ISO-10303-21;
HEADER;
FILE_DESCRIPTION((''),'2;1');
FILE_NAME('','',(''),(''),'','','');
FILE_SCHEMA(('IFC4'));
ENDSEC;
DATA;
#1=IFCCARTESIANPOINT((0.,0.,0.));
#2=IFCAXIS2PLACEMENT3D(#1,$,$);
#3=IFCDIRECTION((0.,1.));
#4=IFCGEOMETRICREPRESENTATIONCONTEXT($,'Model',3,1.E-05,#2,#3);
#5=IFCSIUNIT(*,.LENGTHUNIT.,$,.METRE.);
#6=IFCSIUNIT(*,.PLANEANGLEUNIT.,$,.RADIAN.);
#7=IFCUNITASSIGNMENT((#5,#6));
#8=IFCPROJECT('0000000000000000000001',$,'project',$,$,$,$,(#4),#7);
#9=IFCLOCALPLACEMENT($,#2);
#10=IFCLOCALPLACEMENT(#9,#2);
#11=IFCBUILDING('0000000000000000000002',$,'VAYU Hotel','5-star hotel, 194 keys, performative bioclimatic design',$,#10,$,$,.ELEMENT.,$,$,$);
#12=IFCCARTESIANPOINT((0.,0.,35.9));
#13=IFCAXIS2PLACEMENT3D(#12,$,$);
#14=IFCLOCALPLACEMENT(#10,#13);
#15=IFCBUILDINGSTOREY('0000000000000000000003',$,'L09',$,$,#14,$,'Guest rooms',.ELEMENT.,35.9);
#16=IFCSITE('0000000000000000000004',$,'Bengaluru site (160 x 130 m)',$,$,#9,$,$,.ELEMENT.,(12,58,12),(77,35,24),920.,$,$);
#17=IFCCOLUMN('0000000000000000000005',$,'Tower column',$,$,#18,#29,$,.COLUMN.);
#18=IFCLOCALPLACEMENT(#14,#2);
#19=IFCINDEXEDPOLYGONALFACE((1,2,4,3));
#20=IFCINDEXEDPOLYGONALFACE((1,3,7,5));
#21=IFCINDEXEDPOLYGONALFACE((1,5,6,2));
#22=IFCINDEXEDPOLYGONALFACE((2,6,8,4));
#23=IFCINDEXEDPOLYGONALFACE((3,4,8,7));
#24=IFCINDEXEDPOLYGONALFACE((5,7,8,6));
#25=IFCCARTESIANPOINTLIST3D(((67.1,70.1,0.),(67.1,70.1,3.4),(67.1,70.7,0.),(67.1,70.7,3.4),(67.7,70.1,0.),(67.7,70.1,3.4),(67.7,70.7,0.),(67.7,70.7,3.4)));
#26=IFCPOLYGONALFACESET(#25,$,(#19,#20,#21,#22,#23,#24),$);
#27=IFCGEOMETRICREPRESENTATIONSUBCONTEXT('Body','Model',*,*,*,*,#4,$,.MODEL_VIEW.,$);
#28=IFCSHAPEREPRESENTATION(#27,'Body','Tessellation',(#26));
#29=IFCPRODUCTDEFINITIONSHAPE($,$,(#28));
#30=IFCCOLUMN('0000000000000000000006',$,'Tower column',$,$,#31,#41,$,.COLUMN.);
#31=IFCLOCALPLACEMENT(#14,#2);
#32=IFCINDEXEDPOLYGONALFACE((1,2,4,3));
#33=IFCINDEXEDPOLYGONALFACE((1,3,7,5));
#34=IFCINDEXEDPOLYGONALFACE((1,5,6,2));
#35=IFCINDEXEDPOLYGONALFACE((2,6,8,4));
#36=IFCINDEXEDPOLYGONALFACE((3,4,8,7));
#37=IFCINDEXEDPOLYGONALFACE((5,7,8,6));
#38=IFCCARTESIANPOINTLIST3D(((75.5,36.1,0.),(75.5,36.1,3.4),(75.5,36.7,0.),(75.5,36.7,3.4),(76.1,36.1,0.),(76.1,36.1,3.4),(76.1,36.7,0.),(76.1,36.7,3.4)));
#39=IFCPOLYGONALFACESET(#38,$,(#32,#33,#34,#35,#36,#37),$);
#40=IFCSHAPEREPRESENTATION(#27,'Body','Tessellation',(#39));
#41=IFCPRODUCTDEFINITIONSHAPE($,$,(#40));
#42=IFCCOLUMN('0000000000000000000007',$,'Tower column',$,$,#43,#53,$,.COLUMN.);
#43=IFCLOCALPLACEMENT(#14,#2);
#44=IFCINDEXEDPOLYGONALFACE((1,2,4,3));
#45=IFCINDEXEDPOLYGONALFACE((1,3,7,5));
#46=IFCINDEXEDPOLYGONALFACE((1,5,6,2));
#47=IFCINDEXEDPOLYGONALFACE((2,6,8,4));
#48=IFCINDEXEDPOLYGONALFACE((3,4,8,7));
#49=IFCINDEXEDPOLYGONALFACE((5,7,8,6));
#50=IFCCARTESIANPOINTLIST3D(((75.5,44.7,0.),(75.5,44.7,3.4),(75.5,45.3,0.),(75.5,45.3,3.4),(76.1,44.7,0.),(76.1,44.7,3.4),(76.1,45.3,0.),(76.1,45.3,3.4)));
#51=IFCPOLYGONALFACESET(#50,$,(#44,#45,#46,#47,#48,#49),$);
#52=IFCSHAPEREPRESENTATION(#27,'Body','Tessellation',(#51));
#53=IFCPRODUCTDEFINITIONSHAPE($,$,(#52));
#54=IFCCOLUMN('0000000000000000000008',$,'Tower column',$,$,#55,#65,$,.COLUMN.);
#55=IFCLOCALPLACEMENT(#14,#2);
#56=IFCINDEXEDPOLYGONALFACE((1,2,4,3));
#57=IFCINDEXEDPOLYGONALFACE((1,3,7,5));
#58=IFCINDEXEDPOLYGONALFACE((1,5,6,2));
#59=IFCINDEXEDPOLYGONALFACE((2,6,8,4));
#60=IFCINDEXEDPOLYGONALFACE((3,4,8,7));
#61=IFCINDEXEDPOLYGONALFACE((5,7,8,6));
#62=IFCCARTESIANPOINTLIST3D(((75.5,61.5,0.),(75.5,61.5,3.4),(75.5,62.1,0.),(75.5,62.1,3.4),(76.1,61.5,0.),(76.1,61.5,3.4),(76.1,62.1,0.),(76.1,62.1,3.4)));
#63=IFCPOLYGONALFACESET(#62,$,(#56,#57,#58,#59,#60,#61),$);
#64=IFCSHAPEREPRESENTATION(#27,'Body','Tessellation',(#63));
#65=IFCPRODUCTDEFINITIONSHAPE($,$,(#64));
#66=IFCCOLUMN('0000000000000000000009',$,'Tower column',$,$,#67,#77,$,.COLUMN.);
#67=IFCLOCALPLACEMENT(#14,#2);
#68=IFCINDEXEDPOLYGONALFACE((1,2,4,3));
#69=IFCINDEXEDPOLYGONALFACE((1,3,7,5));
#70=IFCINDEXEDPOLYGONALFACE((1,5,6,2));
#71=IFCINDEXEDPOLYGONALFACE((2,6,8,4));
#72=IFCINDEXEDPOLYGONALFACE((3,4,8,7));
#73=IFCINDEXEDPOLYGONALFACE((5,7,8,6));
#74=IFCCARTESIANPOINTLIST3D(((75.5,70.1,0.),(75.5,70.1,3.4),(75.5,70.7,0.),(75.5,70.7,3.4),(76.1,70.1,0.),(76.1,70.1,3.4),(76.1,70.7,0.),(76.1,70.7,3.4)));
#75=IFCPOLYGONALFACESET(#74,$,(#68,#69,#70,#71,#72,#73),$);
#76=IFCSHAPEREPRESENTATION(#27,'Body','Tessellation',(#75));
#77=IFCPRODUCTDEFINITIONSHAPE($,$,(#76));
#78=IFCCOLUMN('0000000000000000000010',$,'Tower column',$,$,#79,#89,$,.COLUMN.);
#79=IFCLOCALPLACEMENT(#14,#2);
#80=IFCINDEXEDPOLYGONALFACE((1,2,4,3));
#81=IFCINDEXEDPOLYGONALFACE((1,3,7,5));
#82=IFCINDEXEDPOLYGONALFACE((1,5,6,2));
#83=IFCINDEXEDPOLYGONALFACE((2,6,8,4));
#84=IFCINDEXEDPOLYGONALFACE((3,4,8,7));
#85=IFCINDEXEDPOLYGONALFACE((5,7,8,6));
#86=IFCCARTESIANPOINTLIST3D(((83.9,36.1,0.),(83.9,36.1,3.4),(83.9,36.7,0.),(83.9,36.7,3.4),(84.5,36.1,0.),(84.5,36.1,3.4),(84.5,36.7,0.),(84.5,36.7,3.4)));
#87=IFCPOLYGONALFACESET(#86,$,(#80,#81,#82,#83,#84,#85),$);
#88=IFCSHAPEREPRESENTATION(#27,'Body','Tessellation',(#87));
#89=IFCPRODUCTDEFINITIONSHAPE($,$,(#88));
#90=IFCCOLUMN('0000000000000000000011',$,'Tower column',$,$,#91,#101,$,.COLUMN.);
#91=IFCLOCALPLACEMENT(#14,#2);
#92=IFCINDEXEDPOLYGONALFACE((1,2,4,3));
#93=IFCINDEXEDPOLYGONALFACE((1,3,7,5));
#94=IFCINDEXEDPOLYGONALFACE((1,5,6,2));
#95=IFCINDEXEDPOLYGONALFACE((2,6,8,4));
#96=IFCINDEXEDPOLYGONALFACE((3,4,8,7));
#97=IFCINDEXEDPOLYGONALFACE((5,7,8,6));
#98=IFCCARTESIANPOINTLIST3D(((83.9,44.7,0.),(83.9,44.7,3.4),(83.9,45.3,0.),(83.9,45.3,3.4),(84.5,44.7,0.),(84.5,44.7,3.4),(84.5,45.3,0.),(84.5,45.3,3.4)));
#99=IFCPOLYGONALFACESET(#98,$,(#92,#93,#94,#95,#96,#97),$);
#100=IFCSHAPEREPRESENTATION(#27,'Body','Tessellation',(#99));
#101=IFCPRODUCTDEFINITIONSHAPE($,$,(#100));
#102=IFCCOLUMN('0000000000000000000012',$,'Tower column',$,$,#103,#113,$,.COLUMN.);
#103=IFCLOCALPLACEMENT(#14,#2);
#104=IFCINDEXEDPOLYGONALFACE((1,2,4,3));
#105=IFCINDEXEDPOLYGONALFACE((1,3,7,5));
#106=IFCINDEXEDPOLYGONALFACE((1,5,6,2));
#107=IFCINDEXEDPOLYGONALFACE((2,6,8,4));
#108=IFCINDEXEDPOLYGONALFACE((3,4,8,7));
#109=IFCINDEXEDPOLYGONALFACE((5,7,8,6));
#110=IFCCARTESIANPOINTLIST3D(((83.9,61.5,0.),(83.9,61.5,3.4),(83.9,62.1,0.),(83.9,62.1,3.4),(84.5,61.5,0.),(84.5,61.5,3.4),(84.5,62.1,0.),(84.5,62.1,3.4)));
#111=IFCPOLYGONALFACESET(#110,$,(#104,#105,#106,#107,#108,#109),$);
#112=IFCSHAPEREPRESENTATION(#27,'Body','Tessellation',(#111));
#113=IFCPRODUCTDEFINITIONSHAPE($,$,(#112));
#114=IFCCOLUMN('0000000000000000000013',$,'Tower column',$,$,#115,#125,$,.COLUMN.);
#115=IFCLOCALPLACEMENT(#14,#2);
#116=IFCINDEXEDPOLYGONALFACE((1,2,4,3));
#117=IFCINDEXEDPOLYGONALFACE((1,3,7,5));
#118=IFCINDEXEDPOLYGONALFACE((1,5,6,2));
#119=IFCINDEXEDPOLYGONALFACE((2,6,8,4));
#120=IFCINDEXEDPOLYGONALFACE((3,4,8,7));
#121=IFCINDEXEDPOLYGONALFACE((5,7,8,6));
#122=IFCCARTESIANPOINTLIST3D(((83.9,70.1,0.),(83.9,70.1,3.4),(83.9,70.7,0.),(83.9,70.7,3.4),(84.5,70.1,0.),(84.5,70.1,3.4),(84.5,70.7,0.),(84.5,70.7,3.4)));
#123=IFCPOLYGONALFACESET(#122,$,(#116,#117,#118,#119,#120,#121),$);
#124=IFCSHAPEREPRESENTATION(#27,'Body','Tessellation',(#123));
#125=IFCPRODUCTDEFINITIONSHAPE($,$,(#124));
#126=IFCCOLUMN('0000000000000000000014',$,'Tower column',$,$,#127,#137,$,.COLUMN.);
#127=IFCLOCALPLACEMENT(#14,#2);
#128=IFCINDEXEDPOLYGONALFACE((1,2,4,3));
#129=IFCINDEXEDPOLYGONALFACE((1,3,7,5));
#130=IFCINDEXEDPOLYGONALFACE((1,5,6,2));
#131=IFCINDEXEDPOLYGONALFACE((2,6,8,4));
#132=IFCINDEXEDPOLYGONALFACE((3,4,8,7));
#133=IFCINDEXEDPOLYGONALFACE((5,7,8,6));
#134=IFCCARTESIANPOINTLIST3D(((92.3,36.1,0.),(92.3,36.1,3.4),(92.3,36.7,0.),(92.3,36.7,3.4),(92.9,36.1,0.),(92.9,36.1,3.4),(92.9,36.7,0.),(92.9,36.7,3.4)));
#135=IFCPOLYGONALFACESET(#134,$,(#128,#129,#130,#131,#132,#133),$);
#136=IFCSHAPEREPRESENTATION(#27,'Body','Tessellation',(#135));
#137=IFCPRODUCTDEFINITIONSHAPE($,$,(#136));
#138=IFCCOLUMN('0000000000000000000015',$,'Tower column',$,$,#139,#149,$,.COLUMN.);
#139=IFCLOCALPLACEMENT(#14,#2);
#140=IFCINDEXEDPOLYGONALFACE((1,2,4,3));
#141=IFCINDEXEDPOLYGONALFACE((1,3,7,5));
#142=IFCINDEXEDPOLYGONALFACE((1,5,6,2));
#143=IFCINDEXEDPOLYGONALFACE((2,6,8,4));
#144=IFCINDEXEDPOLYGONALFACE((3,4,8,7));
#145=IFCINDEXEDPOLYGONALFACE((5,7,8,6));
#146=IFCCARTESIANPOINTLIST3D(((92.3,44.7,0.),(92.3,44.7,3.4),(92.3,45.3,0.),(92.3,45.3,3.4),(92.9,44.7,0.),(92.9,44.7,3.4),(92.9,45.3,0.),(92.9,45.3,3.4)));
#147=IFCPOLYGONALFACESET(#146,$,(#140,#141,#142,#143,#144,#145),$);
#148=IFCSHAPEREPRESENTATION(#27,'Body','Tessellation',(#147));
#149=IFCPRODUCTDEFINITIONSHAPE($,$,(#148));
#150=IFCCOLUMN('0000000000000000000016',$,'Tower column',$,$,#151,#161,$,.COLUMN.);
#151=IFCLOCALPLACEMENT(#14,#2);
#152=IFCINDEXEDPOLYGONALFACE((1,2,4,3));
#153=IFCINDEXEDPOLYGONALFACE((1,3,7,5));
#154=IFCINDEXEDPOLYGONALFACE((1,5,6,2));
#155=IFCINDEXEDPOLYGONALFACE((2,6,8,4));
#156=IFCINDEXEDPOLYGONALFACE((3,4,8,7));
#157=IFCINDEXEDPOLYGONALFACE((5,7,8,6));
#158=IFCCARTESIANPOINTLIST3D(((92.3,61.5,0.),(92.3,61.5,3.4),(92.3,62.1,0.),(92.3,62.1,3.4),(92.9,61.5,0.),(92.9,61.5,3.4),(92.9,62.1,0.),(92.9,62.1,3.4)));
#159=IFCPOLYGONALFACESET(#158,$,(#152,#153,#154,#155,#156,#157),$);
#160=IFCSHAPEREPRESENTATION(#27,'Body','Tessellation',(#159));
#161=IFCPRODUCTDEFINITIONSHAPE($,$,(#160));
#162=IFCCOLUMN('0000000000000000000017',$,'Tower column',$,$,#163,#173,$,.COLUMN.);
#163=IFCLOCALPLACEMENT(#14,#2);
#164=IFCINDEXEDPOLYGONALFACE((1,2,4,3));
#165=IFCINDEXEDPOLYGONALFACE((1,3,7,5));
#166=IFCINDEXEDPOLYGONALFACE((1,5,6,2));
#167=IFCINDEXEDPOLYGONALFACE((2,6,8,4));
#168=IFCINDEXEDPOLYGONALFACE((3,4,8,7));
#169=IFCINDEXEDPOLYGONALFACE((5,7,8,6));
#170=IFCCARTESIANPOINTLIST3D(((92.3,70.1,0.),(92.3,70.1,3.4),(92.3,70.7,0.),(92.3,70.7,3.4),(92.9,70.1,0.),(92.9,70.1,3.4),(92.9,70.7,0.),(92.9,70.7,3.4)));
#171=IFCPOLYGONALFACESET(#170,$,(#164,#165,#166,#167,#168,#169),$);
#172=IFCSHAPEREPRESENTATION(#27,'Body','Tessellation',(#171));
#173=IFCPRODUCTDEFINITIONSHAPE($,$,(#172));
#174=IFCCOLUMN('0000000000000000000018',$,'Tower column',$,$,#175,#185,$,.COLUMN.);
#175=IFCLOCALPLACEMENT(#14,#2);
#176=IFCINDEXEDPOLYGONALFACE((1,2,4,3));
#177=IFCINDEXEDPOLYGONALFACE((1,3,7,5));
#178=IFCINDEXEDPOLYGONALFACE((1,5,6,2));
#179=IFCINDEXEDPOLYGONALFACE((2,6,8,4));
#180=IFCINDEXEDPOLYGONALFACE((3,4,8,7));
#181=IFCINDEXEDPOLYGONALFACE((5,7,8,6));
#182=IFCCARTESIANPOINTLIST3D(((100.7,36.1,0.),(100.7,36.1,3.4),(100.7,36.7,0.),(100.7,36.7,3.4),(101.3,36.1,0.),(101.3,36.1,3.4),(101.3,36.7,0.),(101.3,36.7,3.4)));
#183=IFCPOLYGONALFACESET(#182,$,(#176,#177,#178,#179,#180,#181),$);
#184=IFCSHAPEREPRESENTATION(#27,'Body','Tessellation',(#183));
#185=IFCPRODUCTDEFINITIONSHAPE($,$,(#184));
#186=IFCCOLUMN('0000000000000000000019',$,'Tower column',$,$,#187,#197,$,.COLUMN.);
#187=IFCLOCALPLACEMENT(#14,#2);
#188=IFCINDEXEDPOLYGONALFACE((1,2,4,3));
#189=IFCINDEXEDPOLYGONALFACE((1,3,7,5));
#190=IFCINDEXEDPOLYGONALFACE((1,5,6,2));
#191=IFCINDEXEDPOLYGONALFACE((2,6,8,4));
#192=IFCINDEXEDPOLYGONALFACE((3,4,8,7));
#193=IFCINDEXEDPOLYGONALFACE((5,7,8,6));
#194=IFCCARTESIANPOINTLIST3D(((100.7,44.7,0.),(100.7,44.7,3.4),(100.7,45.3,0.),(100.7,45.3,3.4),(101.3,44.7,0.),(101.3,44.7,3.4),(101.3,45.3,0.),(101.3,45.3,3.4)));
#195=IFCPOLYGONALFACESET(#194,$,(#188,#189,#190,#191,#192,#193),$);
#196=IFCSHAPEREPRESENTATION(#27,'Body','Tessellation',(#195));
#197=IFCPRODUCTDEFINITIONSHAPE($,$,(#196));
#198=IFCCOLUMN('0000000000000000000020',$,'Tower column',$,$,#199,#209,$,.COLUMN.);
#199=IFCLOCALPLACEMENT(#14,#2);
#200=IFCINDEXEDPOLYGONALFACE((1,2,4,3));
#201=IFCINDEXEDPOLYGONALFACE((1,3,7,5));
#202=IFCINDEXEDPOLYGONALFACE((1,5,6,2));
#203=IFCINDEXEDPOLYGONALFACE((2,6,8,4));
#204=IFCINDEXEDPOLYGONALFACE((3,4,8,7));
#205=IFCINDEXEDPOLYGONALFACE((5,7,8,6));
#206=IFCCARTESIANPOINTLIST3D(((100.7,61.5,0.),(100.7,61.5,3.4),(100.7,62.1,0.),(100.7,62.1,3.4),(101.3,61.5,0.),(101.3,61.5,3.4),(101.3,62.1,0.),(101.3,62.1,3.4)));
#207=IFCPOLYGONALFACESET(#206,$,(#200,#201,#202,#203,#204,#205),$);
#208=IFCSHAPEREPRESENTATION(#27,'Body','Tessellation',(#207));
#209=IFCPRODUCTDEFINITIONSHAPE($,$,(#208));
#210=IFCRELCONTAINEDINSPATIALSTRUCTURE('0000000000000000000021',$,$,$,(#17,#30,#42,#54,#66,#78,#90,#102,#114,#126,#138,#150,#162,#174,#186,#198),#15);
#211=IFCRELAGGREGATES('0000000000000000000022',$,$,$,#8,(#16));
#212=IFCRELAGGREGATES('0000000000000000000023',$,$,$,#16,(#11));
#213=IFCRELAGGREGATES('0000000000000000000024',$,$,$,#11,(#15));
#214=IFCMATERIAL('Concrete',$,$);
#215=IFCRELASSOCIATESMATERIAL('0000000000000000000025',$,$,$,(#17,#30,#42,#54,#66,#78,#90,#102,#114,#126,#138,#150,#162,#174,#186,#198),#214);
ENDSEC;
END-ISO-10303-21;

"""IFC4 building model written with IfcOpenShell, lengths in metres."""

from ifc_helpers import new_model, si_unit, direction, frame, origin, place, context, subcontext, project, spatial, polyline, outline, extrude, material, element, save


model = new_model("IFC4")

# Units and contexts
model_context = context("Model", 3, precision=1e-05, world=origin(), true_north=direction((0.0, 1.0)))
body_context = subcontext(model_context, "Body", "Model", "MODEL_VIEW")
ifc_project = project(units=[si_unit("LENGTHUNIT", "METRE"), si_unit("PLANEANGLEUNIT", "RADIAN")], contexts=[model_context])

# Site, building, storey
site_placement = place(None, origin())
site = spatial("IfcSite", under=ifc_project, at=site_placement, Name="Bengaluru site (160 x 130 m)", CompositionType="ELEMENT", RefLatitude=(12, 58, 12), RefLongitude=(77, 35, 24), RefElevation=920.0)
building_placement = place(site_placement, origin())
building = spatial("IfcBuilding", under=site, at=building_placement, Name="VAYU Hotel", Description="5-star hotel, 194 keys, performative bioclimatic design", CompositionType="ELEMENT")
storey_placement = place(building_placement, frame((0.0, 0.0, 35.9)))
storey = spatial("IfcBuildingStorey", under=building, at=storey_placement, Name="L09", LongName="Guest rooms", CompositionType="ELEMENT", Elevation=35.9)

# Columns
ifc_material = material(Name="Concrete")
column_1_placement = place(storey_placement, origin())
element("IfcColumn", 1, at=column_1_placement, inside=storey, material=ifc_material, Name="Tower column", PredefinedType="COLUMN", context=body_context, shape_type="SweptSolid", body=[
    extrude(outline(polyline([(67.1, 70.1), (67.7, 70.1), (67.7, 70.7), (67.1, 70.7), (67.1, 70.1)])), origin(), (0.0, 0.0, 1.0), 3.4),
])
column_2_placement = place(storey_placement, origin())
element("IfcColumn", 2, at=column_2_placement, inside=storey, material=ifc_material, Name="Tower column", PredefinedType="COLUMN", context=body_context, shape_type="SweptSolid", body=[
    extrude(outline(polyline([(75.5, 36.1), (76.1, 36.1), (76.1, 36.7), (75.5, 36.7), (75.5, 36.1)])), origin(), (0.0, 0.0, 1.0), 3.4),
])
column_3_placement = place(storey_placement, origin())
element("IfcColumn", 3, at=column_3_placement, inside=storey, material=ifc_material, Name="Tower column", PredefinedType="COLUMN", context=body_context, shape_type="SweptSolid", body=[
    extrude(outline(polyline([(75.5, 44.7), (76.1, 44.7), (76.1, 45.3), (75.5, 45.3), (75.5, 44.7)])), origin(), (0.0, 0.0, 1.0), 3.4),
])
column_4_placement = place(storey_placement, origin())
element("IfcColumn", 4, at=column_4_placement, inside=storey, material=ifc_material, Name="Tower column", PredefinedType="COLUMN", context=body_context, shape_type="SweptSolid", body=[
    extrude(outline(polyline([(75.5, 61.5), (76.1, 61.5), (76.1, 62.1), (75.5, 62.1), (75.5, 61.5)])), origin(), (0.0, 0.0, 1.0), 3.4),
])
column_5_placement = place(storey_placement, origin())
element("IfcColumn", 5, at=column_5_placement, inside=storey, material=ifc_material, Name="Tower column", PredefinedType="COLUMN", context=body_context, shape_type="SweptSolid", body=[
    extrude(outline(polyline([(75.5, 70.1), (76.1, 70.1), (76.1, 70.7), (75.5, 70.7), (75.5, 70.1)])), origin(), (0.0, 0.0, 1.0), 3.4),
])
column_6_placement = place(storey_placement, origin())
element("IfcColumn", 6, at=column_6_placement, inside=storey, material=ifc_material, Name="Tower column", PredefinedType="COLUMN", context=body_context, shape_type="SweptSolid", body=[
    extrude(outline(polyline([(83.9, 36.1), (84.5, 36.1), (84.5, 36.7), (83.9, 36.7), (83.9, 36.1)])), origin(), (0.0, 0.0, 1.0), 3.4),
])
column_7_placement = place(storey_placement, origin())
element("IfcColumn", 7, at=column_7_placement, inside=storey, material=ifc_material, Name="Tower column", PredefinedType="COLUMN", context=body_context, shape_type="SweptSolid", body=[
    extrude(outline(polyline([(83.9, 44.7), (84.5, 44.7), (84.5, 45.3), (83.9, 45.3), (83.9, 44.7)])), origin(), (0.0, 0.0, 1.0), 3.4),
])
column_8_placement = place(storey_placement, origin())
element("IfcColumn", 8, at=column_8_placement, inside=storey, material=ifc_material, Name="Tower column", PredefinedType="COLUMN", context=body_context, shape_type="SweptSolid", body=[
    extrude(outline(polyline([(83.9, 61.5), (84.5, 61.5), (84.5, 62.1), (83.9, 62.1), (83.9, 61.5)])), origin(), (0.0, 0.0, 1.0), 3.4),
])
column_9_placement = place(storey_placement, origin())
element("IfcColumn", 9, at=column_9_placement, inside=storey, material=ifc_material, Name="Tower column", PredefinedType="COLUMN", context=body_context, shape_type="SweptSolid", body=[
    extrude(outline(polyline([(83.9, 70.1), (84.5, 70.1), (84.5, 70.7), (83.9, 70.7), (83.9, 70.1)])), origin(), (0.0, 0.0, 1.0), 3.4),
])
column_10_placement = place(storey_placement, origin())
element("IfcColumn", 10, at=column_10_placement, inside=storey, material=ifc_material, Name="Tower column", PredefinedType="COLUMN", context=body_context, shape_type="SweptSolid", body=[
    extrude(outline(polyline([(92.3, 36.1), (92.9, 36.1), (92.9, 36.7), (92.3, 36.7), (92.3, 36.1)])), origin(), (0.0, 0.0, 1.0), 3.4),
])
column_11_placement = place(storey_placement, origin())
element("IfcColumn", 11, at=column_11_placement, inside=storey, material=ifc_material, Name="Tower column", PredefinedType="COLUMN", context=body_context, shape_type="SweptSolid", body=[
    extrude(outline(polyline([(92.3, 44.7), (92.9, 44.7), (92.9, 45.3), (92.3, 45.3), (92.3, 44.7)])), origin(), (0.0, 0.0, 1.0), 3.4),
])
column_12_placement = place(storey_placement, origin())
element("IfcColumn", 12, at=column_12_placement, inside=storey, material=ifc_material, Name="Tower column", PredefinedType="COLUMN", context=body_context, shape_type="SweptSolid", body=[
    extrude(outline(polyline([(92.3, 61.5), (92.9, 61.5), (92.9, 62.1), (92.3, 62.1), (92.3, 61.5)])), origin(), (0.0, 0.0, 1.0), 3.4),
])
column_13_placement = place(storey_placement, origin())
element("IfcColumn", 13, at=column_13_placement, inside=storey, material=ifc_material, Name="Tower column", PredefinedType="COLUMN", context=body_context, shape_type="SweptSolid", body=[
    extrude(outline(polyline([(92.3, 70.1), (92.9, 70.1), (92.9, 70.7), (92.3, 70.7), (92.3, 70.1)])), origin(), (0.0, 0.0, 1.0), 3.4),
])
column_14_placement = place(storey_placement, origin())
element("IfcColumn", 14, at=column_14_placement, inside=storey, material=ifc_material, Name="Tower column", PredefinedType="COLUMN", context=body_context, shape_type="SweptSolid", body=[
    extrude(outline(polyline([(100.7, 36.1), (101.3, 36.1), (101.3, 36.7), (100.7, 36.7), (100.7, 36.1)])), origin(), (0.0, 0.0, 1.0), 3.4),
])
column_15_placement = place(storey_placement, origin())
element("IfcColumn", 15, at=column_15_placement, inside=storey, material=ifc_material, Name="Tower column", PredefinedType="COLUMN", context=body_context, shape_type="SweptSolid", body=[
    extrude(outline(polyline([(100.7, 44.7), (101.3, 44.7), (101.3, 45.3), (100.7, 45.3), (100.7, 44.7)])), origin(), (0.0, 0.0, 1.0), 3.4),
])
column_16_placement = place(storey_placement, origin())
element("IfcColumn", 16, at=column_16_placement, inside=storey, material=ifc_material, Name="Tower column", PredefinedType="COLUMN", context=body_context, shape_type="SweptSolid", body=[
    extrude(outline(polyline([(100.7, 61.5), (101.3, 61.5), (101.3, 62.1), (100.7, 62.1), (100.7, 61.5)])), origin(), (0.0, 0.0, 1.0), 3.4),
])

save(model, "model.ifc")
